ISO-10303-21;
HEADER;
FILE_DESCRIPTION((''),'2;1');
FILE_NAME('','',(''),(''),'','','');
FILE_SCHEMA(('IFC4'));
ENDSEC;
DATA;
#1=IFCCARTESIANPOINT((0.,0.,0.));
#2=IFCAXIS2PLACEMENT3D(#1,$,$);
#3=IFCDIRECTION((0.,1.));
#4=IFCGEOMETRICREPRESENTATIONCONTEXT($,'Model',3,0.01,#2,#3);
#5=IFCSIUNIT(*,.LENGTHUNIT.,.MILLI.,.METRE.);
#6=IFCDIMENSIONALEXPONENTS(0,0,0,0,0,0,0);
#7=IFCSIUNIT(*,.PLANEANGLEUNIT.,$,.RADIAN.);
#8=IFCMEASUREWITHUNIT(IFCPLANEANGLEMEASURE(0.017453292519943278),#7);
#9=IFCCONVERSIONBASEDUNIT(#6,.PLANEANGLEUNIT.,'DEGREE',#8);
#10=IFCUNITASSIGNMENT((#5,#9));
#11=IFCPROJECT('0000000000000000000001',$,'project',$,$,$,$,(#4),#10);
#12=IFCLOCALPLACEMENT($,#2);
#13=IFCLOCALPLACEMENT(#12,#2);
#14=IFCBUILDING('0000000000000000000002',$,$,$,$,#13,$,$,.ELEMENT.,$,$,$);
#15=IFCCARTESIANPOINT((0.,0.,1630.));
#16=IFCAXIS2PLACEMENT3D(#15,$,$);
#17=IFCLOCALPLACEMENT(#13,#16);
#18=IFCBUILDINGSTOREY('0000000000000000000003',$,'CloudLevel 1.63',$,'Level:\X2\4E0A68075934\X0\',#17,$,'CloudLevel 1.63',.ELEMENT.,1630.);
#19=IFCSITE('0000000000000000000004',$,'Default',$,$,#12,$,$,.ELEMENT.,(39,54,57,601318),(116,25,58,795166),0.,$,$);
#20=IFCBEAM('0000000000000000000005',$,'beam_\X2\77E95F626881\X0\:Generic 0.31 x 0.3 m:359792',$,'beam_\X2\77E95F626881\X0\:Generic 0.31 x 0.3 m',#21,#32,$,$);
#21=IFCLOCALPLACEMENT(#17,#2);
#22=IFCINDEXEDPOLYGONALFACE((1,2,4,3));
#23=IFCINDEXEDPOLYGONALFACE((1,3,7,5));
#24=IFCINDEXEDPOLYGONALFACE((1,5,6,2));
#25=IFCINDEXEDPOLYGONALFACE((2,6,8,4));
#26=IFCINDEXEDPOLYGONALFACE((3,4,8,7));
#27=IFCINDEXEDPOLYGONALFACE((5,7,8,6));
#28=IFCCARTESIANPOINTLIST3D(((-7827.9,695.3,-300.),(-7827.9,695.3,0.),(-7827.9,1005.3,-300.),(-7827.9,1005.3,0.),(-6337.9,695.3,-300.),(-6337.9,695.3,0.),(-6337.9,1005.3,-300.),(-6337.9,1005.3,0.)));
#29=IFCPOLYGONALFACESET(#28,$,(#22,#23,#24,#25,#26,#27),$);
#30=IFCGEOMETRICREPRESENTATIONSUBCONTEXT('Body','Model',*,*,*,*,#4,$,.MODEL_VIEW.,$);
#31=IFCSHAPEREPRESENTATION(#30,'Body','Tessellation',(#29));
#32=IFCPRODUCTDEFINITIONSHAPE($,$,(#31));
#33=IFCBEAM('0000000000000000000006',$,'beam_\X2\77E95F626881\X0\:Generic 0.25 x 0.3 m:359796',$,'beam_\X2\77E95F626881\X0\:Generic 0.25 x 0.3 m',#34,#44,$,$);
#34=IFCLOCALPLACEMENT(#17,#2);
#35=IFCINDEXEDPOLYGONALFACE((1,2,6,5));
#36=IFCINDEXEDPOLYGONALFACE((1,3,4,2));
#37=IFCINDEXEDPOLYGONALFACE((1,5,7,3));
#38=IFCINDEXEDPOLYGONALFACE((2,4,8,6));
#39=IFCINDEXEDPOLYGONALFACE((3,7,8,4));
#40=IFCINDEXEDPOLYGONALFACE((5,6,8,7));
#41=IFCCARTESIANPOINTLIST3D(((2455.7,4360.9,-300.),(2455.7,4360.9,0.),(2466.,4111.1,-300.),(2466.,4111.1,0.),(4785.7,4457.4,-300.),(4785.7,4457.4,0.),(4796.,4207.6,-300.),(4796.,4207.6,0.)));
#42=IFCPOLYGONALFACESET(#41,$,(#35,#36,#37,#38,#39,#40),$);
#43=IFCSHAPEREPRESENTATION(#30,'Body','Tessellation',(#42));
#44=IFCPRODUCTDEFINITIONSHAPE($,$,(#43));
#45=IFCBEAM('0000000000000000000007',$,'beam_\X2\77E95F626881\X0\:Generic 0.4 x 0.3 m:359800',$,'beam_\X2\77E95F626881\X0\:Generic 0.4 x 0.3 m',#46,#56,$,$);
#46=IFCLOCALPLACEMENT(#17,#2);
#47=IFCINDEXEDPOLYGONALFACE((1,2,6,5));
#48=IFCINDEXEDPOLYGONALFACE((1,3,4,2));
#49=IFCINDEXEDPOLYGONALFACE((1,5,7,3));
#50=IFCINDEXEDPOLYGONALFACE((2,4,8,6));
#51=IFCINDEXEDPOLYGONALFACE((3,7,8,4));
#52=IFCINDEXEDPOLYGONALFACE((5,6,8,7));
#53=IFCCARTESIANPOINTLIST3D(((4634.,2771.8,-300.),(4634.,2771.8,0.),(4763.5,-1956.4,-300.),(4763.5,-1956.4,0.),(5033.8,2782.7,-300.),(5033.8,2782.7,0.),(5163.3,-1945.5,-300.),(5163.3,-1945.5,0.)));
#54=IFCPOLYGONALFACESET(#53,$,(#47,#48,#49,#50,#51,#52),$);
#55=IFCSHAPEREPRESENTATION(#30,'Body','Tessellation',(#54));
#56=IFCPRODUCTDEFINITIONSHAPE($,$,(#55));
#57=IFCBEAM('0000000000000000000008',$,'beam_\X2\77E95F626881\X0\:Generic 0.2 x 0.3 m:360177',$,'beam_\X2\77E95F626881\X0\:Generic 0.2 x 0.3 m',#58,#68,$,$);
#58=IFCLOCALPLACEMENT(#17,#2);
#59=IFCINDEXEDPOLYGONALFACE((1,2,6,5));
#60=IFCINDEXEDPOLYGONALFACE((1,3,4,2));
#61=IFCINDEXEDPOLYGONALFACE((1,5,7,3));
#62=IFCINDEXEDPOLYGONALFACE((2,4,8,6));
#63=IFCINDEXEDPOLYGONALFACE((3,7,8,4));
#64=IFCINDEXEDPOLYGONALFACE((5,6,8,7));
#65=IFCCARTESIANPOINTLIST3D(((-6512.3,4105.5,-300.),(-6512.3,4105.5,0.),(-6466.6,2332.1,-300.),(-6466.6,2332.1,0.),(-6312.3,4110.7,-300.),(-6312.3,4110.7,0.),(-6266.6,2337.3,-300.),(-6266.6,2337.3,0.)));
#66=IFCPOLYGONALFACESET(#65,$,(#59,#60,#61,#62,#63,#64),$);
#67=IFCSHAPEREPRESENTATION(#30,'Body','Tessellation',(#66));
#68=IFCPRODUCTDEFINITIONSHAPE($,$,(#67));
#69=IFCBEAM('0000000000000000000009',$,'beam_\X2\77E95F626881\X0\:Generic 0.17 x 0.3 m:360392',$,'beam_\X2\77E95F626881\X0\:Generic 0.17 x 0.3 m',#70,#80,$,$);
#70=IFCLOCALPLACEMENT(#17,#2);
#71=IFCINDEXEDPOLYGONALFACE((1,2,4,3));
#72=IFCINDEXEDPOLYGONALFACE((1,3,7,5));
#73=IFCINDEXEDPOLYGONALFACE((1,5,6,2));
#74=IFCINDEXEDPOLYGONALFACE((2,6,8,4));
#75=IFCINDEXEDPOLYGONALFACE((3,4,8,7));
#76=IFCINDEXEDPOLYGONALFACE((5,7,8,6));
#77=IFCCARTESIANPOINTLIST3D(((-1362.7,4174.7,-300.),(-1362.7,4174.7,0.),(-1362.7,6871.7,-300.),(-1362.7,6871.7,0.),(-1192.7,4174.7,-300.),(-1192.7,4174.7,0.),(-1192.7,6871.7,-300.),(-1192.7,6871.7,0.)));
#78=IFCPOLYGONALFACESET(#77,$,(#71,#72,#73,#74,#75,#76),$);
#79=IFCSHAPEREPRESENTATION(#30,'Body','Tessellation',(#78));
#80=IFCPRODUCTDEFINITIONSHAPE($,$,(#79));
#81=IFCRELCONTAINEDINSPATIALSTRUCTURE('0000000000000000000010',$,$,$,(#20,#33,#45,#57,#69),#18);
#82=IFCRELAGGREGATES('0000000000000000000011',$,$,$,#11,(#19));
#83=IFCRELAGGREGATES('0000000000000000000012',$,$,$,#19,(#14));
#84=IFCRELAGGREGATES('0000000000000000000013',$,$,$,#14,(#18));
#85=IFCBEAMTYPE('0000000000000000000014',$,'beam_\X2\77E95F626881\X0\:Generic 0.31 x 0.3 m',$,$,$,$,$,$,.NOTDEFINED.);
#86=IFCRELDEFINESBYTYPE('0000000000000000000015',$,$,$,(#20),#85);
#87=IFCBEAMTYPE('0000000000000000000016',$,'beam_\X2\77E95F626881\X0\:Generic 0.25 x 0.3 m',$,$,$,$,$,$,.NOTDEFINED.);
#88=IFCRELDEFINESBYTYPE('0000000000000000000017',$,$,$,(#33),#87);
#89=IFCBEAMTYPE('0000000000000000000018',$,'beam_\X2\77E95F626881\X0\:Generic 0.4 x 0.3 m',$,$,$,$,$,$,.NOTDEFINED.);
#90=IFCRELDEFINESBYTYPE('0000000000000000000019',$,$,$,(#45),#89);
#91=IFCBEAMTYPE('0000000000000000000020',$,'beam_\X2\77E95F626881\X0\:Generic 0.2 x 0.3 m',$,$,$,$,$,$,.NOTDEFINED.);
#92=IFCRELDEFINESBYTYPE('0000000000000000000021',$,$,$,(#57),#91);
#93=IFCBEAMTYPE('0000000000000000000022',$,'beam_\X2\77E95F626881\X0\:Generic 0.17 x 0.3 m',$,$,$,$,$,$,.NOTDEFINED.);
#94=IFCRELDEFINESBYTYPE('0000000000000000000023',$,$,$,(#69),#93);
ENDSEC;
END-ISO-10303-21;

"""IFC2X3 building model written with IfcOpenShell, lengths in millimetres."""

from ifc_helpers import new_model, entity, si_unit, converted_unit, direction, frame, frame_2d, origin, origin_2d_with_axis, place, context, subcontext, project, spatial, rectangle, extrude, type_object, element, save


model = new_model("IFC2X3")

# Units and contexts
model_context = context("Model", 3, precision=0.01, world=origin(), true_north=direction((0.0, 1.0)))
body_context = subcontext(model_context, "Body", "Model", "MODEL_VIEW")
ifc_project = project(units=[si_unit("LENGTHUNIT", "METRE", prefix="MILLI"), converted_unit("PLANEANGLEUNIT", "DEGREE", entity("IfcPlaneAngleMeasure", 0.017453292519943278), si_unit("PLANEANGLEUNIT", "RADIAN"), dimensions=[0, 0, 0, 0, 0, 0, 0])], contexts=[model_context])

# Site, building, storey
site_placement = place(None, origin())
site = spatial("IfcSite", under=ifc_project, at=site_placement, Name="Default", CompositionType="ELEMENT", RefLatitude=(39, 54, 57, 601318), RefLongitude=(116, 25, 58, 795166), RefElevation=0.0)
building_placement = place(site_placement, origin())
building = spatial("IfcBuilding", under=site, at=building_placement, CompositionType="ELEMENT")
storey_placement = place(building_placement, frame((0.0, 0.0, 1630.0)))
storey = spatial("IfcBuildingStorey", under=building, at=storey_placement, Name="CloudLevel 1.63", ObjectType="Level:上标头", LongName="CloudLevel 1.63", CompositionType="ELEMENT", Elevation=1630.0)

# Beams
beam_type_1 = type_object("IfcBeamType", Name="beam_矩形梁:Generic 0.31 x 0.3 m", PredefinedType="NOTDEFINED")
beam_1_placement = place(storey_placement, frame((-7828.0, 850.3, 0.0)))
element("IfcBeam", 1, at=beam_1_placement, inside=storey, type_object=beam_type_1, Name="beam_矩形梁:Generic 0.31 x 0.3 m:359792", ObjectType="beam_矩形梁:Generic 0.31 x 0.3 m", context=body_context, shape_type="SweptSolid", body=[
    extrude(rectangle(XDim=300.0, YDim=310.0, at=origin_2d_with_axis()), frame((0.1, 0.0, -150.0), z_axis=(1.0, 0.0, 0.0), x_axis=(0.0, 0.0, -1.0)), (0.0, 0.0, 1.0), 1490.0),
])
beam_type_2 = type_object("IfcBeamType", Name="beam_矩形梁:Generic 0.25 x 0.3 m", PredefinedType="NOTDEFINED")
beam_2_placement = place(storey_placement, frame((4791.3, 4332.5, 0.0), z_axis=(0.0, 0.0, 1.0), x_axis=(-0.999143, -0.041384, 0.0)))
element("IfcBeam", 2, at=beam_2_placement, inside=storey, type_object=beam_type_2, Name="beam_矩形梁:Generic 0.25 x 0.3 m:359796", ObjectType="beam_矩形梁:Generic 0.25 x 0.3 m", context=body_context, shape_type="SweptSolid", body=[
    extrude(rectangle(XDim=300.0, YDim=250.0, at=frame_2d((0.0, 0.0), x_axis=(1.0, 0.0))), frame((0.4, 0.0, -150.0), z_axis=(1.0, 0.0, 0.0), x_axis=(0.0, 0.0, -1.0)), (0.0, 0.0, 1.0), 2332.0),
])
beam_type_3 = type_object("IfcBeamType", Name="beam_矩形梁:Generic 0.4 x 0.3 m", PredefinedType="NOTDEFINED")
beam_3_placement = place(storey_placement, frame((4963.4, -1951.2, 0.0), z_axis=(0.0, 0.0, 1.0), x_axis=(-0.027374, 0.999625, 0.0)))
element("IfcBeam", 3, at=beam_3_placement, inside=storey, type_object=beam_type_3, Name="beam_矩形梁:Generic 0.4 x 0.3 m:359800", ObjectType="beam_矩形梁:Generic 0.4 x 0.3 m", context=body_context, shape_type="SweptSolid", body=[
    extrude(rectangle(XDim=300.0, YDim=400.0, at=frame_2d((0.0, 0.0), x_axis=(1.0, 0.0))), frame((0.3, 0.0, -150.0), z_axis=(1.0, 0.0, 0.0), x_axis=(0.0, 0.0, -1.0)), (0.0, 0.0, 1.0), 4730.0),
])
beam_type_4 = type_object("IfcBeamType", Name="beam_矩形梁:Generic 0.2 x 0.3 m", PredefinedType="NOTDEFINED")
beam_4_placement = place(storey_placement, frame((-6366.6, 2334.4, 0.0), z_axis=(0.0, 0.0, 1.0), x_axis=(-0.025761, 0.999668, 0.0)))
element("IfcBeam", 4, at=beam_4_placement, inside=storey, type_object=beam_type_4, Name="beam_矩形梁:Generic 0.2 x 0.3 m:360177", ObjectType="beam_矩形梁:Generic 0.2 x 0.3 m", context=body_context, shape_type="SweptSolid", body=[
    extrude(rectangle(XDim=300.0, YDim=200.0, at=frame_2d((0.0, 0.0), x_axis=(1.0, 0.0))), frame((0.3, 0.0, -150.0), z_axis=(1.0, 0.0, 0.0), x_axis=(0.0, 0.0, -1.0)), (0.0, 0.0, 1.0), 1774.0),
])
beam_type_5 = type_object("IfcBeamType", Name="beam_矩形梁:Generic 0.17 x 0.3 m", PredefinedType="NOTDEFINED")
beam_5_placement = place(storey_placement, frame((-1277.7, 6871.8, 0.0), z_axis=(0.0, 0.0, 1.0), x_axis=(0.0, -1.0, 0.0)))
element("IfcBeam", 5, at=beam_5_placement, inside=storey, type_object=beam_type_5, Name="beam_矩形梁:Generic 0.17 x 0.3 m:360392", ObjectType="beam_矩形梁:Generic 0.17 x 0.3 m", context=body_context, shape_type="SweptSolid", body=[
    extrude(rectangle(XDim=300.0, YDim=170.0, at=frame_2d((0.0, 0.0), x_axis=(1.0, 0.0))), frame((0.1, 0.0, -150.0), z_axis=(1.0, 0.0, 0.0), x_axis=(0.0, 0.0, -1.0)), (0.0, 0.0, 1.0), 2697.0),
])

save(model, "model.ifc")
